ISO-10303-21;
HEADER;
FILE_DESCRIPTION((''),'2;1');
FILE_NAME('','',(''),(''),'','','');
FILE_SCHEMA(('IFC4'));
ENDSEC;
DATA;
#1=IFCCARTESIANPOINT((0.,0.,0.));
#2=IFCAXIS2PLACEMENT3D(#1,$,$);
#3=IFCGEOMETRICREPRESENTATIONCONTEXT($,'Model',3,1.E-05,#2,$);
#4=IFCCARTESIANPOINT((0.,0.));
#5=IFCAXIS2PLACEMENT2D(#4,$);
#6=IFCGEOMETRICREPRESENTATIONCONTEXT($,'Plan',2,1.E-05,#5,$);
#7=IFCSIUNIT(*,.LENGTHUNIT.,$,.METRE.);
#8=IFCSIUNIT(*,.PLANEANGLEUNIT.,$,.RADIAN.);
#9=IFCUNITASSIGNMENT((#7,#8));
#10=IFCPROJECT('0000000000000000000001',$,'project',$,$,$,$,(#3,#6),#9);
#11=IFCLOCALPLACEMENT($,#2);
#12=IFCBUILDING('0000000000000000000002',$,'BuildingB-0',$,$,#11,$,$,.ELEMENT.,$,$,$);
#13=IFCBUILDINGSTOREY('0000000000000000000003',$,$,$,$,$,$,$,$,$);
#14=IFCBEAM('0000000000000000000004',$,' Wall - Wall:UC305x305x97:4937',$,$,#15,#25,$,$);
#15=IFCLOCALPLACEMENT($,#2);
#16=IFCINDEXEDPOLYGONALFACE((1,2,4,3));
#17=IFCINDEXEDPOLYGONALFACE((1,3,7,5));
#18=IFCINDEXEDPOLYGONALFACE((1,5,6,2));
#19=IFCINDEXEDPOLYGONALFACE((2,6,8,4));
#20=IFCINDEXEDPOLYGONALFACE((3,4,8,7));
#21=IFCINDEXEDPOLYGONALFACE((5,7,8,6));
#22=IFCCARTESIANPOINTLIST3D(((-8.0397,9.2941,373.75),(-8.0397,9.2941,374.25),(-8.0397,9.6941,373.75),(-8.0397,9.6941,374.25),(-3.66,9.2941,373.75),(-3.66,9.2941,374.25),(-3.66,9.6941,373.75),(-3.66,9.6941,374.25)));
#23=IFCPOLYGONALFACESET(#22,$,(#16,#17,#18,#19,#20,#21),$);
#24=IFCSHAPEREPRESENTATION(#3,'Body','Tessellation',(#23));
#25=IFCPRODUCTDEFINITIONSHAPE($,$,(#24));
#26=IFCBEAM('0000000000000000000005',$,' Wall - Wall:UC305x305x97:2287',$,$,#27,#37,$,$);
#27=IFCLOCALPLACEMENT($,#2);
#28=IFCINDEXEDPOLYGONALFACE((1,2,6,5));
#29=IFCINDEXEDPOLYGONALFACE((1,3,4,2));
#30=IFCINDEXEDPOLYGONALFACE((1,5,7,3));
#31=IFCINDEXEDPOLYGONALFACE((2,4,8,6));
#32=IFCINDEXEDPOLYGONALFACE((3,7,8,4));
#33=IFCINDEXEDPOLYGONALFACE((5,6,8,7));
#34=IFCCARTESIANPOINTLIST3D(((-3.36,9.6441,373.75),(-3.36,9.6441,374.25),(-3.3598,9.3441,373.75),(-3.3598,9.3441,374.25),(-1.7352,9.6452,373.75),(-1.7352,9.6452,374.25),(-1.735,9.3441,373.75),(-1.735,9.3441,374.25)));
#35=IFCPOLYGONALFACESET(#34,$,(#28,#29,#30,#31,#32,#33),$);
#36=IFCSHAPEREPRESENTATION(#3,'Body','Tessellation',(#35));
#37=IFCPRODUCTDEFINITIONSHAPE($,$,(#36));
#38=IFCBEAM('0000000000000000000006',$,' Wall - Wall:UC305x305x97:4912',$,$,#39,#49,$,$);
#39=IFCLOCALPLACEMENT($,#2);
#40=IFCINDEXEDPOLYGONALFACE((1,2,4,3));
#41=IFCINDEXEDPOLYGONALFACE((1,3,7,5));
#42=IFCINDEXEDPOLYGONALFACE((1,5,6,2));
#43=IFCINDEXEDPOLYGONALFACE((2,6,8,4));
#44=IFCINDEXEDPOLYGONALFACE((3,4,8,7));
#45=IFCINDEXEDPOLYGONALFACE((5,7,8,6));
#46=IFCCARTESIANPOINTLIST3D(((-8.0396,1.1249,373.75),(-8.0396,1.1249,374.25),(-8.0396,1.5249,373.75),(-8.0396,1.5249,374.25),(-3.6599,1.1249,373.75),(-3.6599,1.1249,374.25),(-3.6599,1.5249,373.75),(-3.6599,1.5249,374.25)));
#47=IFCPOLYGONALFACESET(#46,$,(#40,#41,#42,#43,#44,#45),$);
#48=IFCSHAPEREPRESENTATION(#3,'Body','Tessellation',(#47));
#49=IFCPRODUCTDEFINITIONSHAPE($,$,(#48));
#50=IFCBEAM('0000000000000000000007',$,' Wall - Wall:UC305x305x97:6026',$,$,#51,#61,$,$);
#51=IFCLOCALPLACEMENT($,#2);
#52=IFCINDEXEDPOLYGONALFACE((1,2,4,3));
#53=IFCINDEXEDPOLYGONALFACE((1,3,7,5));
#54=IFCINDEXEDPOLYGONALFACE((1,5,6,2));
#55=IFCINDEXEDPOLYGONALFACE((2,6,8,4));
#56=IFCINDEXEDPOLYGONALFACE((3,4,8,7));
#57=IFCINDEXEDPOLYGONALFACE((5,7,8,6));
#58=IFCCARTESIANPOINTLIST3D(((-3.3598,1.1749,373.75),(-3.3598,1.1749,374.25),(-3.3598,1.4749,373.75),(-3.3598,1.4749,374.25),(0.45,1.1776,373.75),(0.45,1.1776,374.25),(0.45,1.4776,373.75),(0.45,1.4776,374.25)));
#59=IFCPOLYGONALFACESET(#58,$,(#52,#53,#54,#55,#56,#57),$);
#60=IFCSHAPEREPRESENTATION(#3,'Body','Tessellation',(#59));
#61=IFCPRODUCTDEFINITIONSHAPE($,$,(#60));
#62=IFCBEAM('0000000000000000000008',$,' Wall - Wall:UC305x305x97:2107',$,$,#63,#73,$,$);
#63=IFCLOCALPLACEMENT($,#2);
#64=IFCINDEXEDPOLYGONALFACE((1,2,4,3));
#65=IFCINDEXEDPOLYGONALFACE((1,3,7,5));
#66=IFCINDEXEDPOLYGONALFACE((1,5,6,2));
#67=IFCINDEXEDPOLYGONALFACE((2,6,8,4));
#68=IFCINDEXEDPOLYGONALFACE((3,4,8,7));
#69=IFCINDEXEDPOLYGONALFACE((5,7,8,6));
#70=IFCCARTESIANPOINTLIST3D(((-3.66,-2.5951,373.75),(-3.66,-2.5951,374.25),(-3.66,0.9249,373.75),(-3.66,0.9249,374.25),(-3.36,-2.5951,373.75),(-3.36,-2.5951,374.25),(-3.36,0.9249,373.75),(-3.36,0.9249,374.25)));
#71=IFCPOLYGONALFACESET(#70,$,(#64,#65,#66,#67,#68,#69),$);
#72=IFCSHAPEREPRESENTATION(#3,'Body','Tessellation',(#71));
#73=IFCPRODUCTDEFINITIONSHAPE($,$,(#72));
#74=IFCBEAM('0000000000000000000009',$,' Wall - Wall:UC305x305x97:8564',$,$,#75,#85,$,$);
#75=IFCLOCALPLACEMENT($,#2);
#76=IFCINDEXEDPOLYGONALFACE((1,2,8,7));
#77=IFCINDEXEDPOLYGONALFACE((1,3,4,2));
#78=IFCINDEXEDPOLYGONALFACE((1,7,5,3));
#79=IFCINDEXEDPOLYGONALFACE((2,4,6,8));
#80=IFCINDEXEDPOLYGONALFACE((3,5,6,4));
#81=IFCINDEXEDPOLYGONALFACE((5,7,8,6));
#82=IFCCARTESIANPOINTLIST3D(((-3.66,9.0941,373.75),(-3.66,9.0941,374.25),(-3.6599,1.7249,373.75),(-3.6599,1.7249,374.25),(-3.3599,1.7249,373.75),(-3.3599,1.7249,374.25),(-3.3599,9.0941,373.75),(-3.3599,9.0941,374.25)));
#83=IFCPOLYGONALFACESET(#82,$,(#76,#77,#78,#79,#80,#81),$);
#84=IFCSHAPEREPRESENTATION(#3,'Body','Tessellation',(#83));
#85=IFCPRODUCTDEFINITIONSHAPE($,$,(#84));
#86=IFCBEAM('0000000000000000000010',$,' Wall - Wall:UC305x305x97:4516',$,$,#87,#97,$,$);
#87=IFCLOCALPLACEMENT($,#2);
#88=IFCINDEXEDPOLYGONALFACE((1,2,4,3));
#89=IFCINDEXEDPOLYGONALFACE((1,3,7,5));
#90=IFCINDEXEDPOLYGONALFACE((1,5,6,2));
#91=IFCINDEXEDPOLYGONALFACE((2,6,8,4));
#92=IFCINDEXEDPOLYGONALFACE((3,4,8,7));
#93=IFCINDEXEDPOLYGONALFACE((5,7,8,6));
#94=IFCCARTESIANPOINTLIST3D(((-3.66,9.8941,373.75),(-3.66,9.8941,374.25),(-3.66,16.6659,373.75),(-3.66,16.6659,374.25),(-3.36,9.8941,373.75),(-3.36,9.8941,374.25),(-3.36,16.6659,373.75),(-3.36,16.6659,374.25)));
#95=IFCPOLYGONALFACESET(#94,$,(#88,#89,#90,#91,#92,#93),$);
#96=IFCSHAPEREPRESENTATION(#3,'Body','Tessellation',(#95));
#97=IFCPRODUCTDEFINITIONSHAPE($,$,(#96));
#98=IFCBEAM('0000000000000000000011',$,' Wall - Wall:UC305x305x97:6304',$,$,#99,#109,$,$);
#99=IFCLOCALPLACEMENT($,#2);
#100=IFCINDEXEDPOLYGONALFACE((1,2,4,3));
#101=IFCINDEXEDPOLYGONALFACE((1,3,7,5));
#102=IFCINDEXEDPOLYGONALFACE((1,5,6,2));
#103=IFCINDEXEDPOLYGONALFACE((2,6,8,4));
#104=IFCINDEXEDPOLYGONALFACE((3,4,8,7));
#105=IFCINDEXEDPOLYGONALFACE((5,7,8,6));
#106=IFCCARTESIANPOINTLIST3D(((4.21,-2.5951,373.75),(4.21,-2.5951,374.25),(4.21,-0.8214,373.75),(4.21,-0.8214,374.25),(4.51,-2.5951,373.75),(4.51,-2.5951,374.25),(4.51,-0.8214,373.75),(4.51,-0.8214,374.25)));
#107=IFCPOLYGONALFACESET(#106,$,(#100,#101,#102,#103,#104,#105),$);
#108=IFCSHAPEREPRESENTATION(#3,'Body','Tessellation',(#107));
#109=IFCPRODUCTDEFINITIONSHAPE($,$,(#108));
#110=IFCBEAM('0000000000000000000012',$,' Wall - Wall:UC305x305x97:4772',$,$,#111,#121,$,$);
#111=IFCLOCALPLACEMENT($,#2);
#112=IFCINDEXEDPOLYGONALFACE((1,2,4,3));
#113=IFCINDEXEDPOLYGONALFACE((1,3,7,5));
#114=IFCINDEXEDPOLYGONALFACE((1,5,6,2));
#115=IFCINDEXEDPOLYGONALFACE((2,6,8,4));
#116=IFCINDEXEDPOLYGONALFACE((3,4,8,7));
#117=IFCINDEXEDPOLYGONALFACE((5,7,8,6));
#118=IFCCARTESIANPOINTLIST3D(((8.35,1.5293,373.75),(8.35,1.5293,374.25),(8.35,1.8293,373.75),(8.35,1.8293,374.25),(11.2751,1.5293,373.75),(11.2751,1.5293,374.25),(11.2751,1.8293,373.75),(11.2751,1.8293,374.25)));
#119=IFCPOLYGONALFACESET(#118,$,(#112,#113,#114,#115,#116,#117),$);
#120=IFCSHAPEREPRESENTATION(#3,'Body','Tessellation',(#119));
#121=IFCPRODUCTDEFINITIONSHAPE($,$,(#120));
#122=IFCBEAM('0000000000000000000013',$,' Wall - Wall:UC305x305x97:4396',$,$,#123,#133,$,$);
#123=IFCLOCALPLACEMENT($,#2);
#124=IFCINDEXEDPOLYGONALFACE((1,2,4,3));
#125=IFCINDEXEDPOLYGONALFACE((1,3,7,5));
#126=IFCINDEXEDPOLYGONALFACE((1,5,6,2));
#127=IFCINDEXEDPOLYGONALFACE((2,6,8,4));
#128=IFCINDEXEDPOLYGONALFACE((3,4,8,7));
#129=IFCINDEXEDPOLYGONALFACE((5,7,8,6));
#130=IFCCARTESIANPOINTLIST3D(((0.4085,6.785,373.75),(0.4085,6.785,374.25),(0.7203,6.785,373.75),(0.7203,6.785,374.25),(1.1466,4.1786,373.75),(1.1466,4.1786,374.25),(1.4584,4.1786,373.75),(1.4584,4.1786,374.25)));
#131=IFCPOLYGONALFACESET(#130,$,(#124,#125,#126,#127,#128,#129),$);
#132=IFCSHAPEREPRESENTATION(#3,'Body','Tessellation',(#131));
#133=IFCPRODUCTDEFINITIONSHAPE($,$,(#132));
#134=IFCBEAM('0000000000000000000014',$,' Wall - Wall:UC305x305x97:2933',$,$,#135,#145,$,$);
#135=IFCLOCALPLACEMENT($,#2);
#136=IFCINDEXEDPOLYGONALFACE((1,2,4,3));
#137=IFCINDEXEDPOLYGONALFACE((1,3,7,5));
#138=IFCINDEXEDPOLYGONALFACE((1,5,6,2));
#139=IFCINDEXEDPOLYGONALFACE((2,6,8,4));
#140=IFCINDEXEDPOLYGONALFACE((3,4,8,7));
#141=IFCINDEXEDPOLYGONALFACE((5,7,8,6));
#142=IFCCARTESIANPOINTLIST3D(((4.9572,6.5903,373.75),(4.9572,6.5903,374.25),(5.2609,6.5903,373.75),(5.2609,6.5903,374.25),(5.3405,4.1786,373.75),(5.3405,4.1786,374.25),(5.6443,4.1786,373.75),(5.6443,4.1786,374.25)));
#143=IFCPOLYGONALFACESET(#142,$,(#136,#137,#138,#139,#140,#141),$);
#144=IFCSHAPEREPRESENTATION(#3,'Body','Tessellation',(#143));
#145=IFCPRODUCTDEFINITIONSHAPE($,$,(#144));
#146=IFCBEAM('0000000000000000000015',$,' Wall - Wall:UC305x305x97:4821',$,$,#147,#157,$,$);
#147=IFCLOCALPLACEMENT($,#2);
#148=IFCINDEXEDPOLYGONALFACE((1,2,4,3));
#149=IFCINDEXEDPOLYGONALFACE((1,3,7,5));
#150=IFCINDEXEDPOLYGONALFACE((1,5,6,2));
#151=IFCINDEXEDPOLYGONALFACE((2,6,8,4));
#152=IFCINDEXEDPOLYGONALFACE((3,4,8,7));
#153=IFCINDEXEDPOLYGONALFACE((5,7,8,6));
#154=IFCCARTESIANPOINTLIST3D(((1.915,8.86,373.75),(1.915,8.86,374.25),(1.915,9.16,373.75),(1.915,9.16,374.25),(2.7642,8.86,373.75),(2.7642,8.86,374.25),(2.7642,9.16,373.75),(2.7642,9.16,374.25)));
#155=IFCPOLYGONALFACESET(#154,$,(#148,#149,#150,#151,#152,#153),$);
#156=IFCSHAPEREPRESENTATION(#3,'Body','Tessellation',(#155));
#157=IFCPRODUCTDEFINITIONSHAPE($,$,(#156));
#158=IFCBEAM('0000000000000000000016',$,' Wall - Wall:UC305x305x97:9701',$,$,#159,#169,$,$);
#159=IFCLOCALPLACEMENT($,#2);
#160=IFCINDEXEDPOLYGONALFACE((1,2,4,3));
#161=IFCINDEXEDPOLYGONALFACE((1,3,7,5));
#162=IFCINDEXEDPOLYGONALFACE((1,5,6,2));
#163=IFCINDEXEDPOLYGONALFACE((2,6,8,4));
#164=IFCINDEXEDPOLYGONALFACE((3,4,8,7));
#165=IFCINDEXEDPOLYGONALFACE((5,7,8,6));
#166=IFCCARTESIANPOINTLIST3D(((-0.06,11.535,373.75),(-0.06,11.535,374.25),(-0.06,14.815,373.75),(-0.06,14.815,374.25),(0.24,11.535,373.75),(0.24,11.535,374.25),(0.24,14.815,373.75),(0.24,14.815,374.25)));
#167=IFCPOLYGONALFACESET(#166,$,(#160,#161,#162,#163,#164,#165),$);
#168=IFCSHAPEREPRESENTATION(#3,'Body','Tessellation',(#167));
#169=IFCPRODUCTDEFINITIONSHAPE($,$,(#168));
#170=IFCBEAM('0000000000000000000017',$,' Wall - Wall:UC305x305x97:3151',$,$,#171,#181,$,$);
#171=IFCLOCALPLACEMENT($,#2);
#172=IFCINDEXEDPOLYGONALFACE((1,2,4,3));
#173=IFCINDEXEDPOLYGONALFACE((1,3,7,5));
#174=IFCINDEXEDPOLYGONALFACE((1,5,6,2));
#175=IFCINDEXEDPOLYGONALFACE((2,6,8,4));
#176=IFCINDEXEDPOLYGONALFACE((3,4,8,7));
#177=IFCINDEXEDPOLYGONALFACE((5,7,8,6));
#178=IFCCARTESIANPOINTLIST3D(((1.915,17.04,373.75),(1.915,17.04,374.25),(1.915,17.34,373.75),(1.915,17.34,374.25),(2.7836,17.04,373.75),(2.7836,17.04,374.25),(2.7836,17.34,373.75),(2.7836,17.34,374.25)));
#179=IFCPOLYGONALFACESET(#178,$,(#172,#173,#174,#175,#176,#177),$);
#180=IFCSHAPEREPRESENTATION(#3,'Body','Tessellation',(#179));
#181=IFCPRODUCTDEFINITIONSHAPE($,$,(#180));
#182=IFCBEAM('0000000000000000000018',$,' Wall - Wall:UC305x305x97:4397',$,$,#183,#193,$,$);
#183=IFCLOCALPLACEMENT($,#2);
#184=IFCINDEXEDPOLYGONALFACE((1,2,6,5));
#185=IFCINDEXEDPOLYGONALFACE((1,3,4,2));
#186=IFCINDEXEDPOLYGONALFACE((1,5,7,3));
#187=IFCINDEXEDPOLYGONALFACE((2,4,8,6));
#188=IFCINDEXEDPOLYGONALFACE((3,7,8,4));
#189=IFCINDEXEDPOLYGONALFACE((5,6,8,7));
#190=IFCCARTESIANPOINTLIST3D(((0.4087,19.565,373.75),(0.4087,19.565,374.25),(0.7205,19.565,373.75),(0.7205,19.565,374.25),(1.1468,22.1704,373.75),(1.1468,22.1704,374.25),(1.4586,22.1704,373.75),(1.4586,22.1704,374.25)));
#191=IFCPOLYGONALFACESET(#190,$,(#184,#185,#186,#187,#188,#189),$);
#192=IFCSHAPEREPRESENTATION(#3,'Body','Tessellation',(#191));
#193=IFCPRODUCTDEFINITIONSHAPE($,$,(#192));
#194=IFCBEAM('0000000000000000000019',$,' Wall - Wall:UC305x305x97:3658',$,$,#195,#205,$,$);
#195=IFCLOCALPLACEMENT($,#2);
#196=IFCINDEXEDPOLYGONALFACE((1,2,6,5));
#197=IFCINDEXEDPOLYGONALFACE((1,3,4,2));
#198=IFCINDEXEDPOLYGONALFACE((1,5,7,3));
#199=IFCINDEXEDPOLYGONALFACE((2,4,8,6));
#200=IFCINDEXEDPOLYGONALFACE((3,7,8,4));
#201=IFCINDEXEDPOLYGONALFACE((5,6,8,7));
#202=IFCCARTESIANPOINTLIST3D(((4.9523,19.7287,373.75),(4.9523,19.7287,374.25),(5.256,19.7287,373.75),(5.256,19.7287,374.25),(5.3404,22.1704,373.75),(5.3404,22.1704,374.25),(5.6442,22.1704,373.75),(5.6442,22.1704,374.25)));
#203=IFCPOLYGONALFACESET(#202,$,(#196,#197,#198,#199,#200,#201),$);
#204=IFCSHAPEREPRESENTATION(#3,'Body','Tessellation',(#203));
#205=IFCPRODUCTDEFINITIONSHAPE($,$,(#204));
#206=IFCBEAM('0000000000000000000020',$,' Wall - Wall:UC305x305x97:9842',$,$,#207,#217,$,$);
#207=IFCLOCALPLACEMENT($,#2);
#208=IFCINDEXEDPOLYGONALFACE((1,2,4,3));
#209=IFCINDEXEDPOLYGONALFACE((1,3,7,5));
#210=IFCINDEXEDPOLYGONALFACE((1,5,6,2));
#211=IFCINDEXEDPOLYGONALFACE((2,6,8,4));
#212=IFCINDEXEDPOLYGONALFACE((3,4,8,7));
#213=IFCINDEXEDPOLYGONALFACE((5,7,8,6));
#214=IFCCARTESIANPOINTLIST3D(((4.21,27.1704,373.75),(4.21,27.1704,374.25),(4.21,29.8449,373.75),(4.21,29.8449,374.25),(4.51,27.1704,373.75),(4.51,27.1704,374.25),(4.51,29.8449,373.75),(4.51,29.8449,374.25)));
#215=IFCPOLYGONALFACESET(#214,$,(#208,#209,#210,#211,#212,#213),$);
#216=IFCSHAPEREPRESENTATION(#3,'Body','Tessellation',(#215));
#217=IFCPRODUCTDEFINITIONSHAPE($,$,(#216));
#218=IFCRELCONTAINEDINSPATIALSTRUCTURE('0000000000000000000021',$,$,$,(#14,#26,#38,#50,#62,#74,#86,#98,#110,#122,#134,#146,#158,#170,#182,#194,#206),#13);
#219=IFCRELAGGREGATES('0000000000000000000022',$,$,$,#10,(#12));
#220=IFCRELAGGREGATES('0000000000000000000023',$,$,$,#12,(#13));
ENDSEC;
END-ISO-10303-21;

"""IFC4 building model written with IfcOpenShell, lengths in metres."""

from ifc_helpers import new_model, si_unit, origin, origin_2d, place, context, project, spatial, polyline, outline, extrude, element, save


model = new_model("IFC4")

# Units and contexts
model_context = context("Model", 3, precision=1e-05, world=origin())
plan_context = context("Plan", 2, precision=1e-05, world=origin_2d())
ifc_project = project(units=[si_unit("LENGTHUNIT", "METRE"), si_unit("PLANEANGLEUNIT", "RADIAN")], contexts=[model_context, plan_context])

# Building, storey
building_placement = place(None, origin())
building = spatial("IfcBuilding", under=ifc_project, at=building_placement, Name="BuildingB-0", CompositionType="ELEMENT")
storey = spatial("IfcBuildingStorey", under=building)

# Beams
element("IfcBeam", 1, inside=storey, Name=" Wall - Wall:UC305x305x97:4937", context=model_context, shape_type="SweptSolid", body=[
    extrude(outline(polyline([(-8.0397, 9.6941, 373.75), (-8.0397, 9.2941, 373.75), (-3.66, 9.2941, 373.75), (-3.66, 9.6941, 373.75), (-8.0397, 9.6941, 373.75)])), None, (0.0, 0.0, 1.0), 0.5),
])
element("IfcBeam", 2, inside=storey, Name=" Wall - Wall:UC305x305x97:2287", context=model_context, shape_type="SweptSolid", body=[
    extrude(outline(polyline([(-3.3598, 9.3441, 373.75), (-1.735, 9.3441, 373.75), (-1.7352, 9.6452, 373.75), (-3.36, 9.6441, 373.75), (-3.3598, 9.3441, 373.75)])), None, (0.0, 0.0, 1.0), 0.5),
])
element("IfcBeam", 3, inside=storey, Name=" Wall - Wall:UC305x305x97:4912", context=model_context, shape_type="SweptSolid", body=[
    extrude(outline(polyline([(-8.0396, 1.1249, 373.75), (-8.0396, 1.5249, 373.75), (-3.6599, 1.5249, 373.75), (-3.6599, 1.1249, 373.75), (-8.0396, 1.1249, 373.75)])), None, (0.0, 0.0, 1.0), 0.5),
])
element("IfcBeam", 4, inside=storey, Name=" Wall - Wall:UC305x305x97:6026", context=model_context, shape_type="SweptSolid", body=[
    extrude(outline(polyline([(-3.3598, 1.1749, 373.75), (-3.3598, 1.4749, 373.75), (0.45, 1.4776, 373.75), (0.45, 1.1776, 373.75), (-3.3598, 1.1749, 373.75)])), None, (0.0, 0.0, 1.0), 0.5),
])
element("IfcBeam", 5, inside=storey, Name=" Wall - Wall:UC305x305x97:2107", context=model_context, shape_type="SweptSolid", body=[
    extrude(outline(polyline([(-3.66, -2.5951, 373.75), (-3.36, -2.5951, 373.75), (-3.36, 0.9249, 373.75), (-3.66, 0.9249, 373.75), (-3.66, -2.5951, 373.75)])), None, (0.0, 0.0, 1.0), 0.5),
])
element("IfcBeam", 6, inside=storey, Name=" Wall - Wall:UC305x305x97:8564", context=model_context, shape_type="SweptSolid", body=[
    extrude(outline(polyline([(-3.6599, 1.7249, 373.75), (-3.3599, 1.7249, 373.75), (-3.3599, 9.0941, 373.75), (-3.66, 9.0941, 373.75), (-3.6599, 1.7249, 373.75)])), None, (0.0, 0.0, 1.0), 0.5),
])
element("IfcBeam", 7, inside=storey, Name=" Wall - Wall:UC305x305x97:4516", context=model_context, shape_type="SweptSolid", body=[
    extrude(outline(polyline([(-3.66, 9.8941, 373.75), (-3.36, 9.8941, 373.75), (-3.36, 16.6659, 373.75), (-3.66, 16.6659, 373.75), (-3.66, 9.8941, 373.75)])), None, (0.0, 0.0, 1.0), 0.5),
])
element("IfcBeam", 8, inside=storey, Name=" Wall - Wall:UC305x305x97:6304", context=model_context, shape_type="SweptSolid", body=[
    extrude(outline(polyline([(4.21, -2.5951, 373.75), (4.51, -2.5951, 373.75), (4.51, -0.8214, 373.75), (4.21, -0.8214, 373.75), (4.21, -2.5951, 373.75)])), None, (0.0, 0.0, 1.0), 0.5),
])
element("IfcBeam", 9, inside=storey, Name=" Wall - Wall:UC305x305x97:4772", context=model_context, shape_type="SweptSolid", body=[
    extrude(outline(polyline([(8.35, 1.5293, 373.75), (8.35, 1.8293, 373.75), (11.2751, 1.8293, 373.75), (11.2751, 1.5293, 373.75), (8.35, 1.5293, 373.75)])), None, (0.0, 0.0, 1.0), 0.5),
])
element("IfcBeam", 10, inside=storey, Name=" Wall - Wall:UC305x305x97:4396", context=model_context, shape_type="SweptSolid", body=[
    extrude(outline(polyline([(1.1466, 4.1786, 373.75), (0.4085, 6.785, 373.75), (0.7203, 6.785, 373.75), (1.4584, 4.1786, 373.75), (1.1466, 4.1786, 373.75)])), None, (0.0, 0.0, 1.0), 0.5),
])
element("IfcBeam", 11, inside=storey, Name=" Wall - Wall:UC305x305x97:2933", context=model_context, shape_type="SweptSolid", body=[
    extrude(outline(polyline([(5.3405, 4.1786, 373.75), (4.9572, 6.5903, 373.75), (5.2609, 6.5903, 373.75), (5.6443, 4.1786, 373.75), (5.3405, 4.1786, 373.75)])), None, (0.0, 0.0, 1.0), 0.5),
])
element("IfcBeam", 12, inside=storey, Name=" Wall - Wall:UC305x305x97:4821", context=model_context, shape_type="SweptSolid", body=[
    extrude(outline(polyline([(1.915, 8.86, 373.75), (1.915, 9.16, 373.75), (2.7642, 9.16, 373.75), (2.7642, 8.86, 373.75), (1.915, 8.86, 373.75)])), None, (0.0, 0.0, 1.0), 0.5),
])
element("IfcBeam", 13, inside=storey, Name=" Wall - Wall:UC305x305x97:9701", context=model_context, shape_type="SweptSolid", body=[
    extrude(outline(polyline([(-0.06, 11.535, 373.75), (-0.06, 14.815, 373.75), (0.24, 14.815, 373.75), (0.24, 11.535, 373.75), (-0.06, 11.535, 373.75)])), None, (0.0, 0.0, 1.0), 0.5),
])
element("IfcBeam", 14, inside=storey, Name=" Wall - Wall:UC305x305x97:3151", context=model_context, shape_type="SweptSolid", body=[
    extrude(outline(polyline([(1.915, 17.04, 373.75), (1.915, 17.34, 373.75), (2.7836, 17.34, 373.75), (2.7836, 17.04, 373.75), (1.915, 17.04, 373.75)])), None, (0.0, 0.0, 1.0), 0.5),
])
element("IfcBeam", 15, inside=storey, Name=" Wall - Wall:UC305x305x97:4397", context=model_context, shape_type="SweptSolid", body=[
    extrude(outline(polyline([(0.4087, 19.565, 373.75), (1.1468, 22.1704, 373.75), (1.4586, 22.1704, 373.75), (0.7205, 19.565, 373.75), (0.4087, 19.565, 373.75)])), None, (0.0, 0.0, 1.0), 0.5),
])
element("IfcBeam", 16, inside=storey, Name=" Wall - Wall:UC305x305x97:3658", context=model_context, shape_type="SweptSolid", body=[
    extrude(outline(polyline([(5.256, 19.7287, 373.75), (4.9523, 19.7287, 373.75), (5.3404, 22.1704, 373.75), (5.6442, 22.1704, 373.75), (5.256, 19.7287, 373.75)])), None, (0.0, 0.0, 1.0), 0.5),
])
element("IfcBeam", 17, inside=storey, Name=" Wall - Wall:UC305x305x97:9842", context=model_context, shape_type="SweptSolid", body=[
    extrude(outline(polyline([(4.51, 27.1704, 373.75), (4.21, 27.1704, 373.75), (4.21, 29.8449, 373.75), (4.51, 29.8449, 373.75), (4.51, 27.1704, 373.75)])), None, (0.0, 0.0, 1.0), 0.5),
])

save(model, "model.ifc")
